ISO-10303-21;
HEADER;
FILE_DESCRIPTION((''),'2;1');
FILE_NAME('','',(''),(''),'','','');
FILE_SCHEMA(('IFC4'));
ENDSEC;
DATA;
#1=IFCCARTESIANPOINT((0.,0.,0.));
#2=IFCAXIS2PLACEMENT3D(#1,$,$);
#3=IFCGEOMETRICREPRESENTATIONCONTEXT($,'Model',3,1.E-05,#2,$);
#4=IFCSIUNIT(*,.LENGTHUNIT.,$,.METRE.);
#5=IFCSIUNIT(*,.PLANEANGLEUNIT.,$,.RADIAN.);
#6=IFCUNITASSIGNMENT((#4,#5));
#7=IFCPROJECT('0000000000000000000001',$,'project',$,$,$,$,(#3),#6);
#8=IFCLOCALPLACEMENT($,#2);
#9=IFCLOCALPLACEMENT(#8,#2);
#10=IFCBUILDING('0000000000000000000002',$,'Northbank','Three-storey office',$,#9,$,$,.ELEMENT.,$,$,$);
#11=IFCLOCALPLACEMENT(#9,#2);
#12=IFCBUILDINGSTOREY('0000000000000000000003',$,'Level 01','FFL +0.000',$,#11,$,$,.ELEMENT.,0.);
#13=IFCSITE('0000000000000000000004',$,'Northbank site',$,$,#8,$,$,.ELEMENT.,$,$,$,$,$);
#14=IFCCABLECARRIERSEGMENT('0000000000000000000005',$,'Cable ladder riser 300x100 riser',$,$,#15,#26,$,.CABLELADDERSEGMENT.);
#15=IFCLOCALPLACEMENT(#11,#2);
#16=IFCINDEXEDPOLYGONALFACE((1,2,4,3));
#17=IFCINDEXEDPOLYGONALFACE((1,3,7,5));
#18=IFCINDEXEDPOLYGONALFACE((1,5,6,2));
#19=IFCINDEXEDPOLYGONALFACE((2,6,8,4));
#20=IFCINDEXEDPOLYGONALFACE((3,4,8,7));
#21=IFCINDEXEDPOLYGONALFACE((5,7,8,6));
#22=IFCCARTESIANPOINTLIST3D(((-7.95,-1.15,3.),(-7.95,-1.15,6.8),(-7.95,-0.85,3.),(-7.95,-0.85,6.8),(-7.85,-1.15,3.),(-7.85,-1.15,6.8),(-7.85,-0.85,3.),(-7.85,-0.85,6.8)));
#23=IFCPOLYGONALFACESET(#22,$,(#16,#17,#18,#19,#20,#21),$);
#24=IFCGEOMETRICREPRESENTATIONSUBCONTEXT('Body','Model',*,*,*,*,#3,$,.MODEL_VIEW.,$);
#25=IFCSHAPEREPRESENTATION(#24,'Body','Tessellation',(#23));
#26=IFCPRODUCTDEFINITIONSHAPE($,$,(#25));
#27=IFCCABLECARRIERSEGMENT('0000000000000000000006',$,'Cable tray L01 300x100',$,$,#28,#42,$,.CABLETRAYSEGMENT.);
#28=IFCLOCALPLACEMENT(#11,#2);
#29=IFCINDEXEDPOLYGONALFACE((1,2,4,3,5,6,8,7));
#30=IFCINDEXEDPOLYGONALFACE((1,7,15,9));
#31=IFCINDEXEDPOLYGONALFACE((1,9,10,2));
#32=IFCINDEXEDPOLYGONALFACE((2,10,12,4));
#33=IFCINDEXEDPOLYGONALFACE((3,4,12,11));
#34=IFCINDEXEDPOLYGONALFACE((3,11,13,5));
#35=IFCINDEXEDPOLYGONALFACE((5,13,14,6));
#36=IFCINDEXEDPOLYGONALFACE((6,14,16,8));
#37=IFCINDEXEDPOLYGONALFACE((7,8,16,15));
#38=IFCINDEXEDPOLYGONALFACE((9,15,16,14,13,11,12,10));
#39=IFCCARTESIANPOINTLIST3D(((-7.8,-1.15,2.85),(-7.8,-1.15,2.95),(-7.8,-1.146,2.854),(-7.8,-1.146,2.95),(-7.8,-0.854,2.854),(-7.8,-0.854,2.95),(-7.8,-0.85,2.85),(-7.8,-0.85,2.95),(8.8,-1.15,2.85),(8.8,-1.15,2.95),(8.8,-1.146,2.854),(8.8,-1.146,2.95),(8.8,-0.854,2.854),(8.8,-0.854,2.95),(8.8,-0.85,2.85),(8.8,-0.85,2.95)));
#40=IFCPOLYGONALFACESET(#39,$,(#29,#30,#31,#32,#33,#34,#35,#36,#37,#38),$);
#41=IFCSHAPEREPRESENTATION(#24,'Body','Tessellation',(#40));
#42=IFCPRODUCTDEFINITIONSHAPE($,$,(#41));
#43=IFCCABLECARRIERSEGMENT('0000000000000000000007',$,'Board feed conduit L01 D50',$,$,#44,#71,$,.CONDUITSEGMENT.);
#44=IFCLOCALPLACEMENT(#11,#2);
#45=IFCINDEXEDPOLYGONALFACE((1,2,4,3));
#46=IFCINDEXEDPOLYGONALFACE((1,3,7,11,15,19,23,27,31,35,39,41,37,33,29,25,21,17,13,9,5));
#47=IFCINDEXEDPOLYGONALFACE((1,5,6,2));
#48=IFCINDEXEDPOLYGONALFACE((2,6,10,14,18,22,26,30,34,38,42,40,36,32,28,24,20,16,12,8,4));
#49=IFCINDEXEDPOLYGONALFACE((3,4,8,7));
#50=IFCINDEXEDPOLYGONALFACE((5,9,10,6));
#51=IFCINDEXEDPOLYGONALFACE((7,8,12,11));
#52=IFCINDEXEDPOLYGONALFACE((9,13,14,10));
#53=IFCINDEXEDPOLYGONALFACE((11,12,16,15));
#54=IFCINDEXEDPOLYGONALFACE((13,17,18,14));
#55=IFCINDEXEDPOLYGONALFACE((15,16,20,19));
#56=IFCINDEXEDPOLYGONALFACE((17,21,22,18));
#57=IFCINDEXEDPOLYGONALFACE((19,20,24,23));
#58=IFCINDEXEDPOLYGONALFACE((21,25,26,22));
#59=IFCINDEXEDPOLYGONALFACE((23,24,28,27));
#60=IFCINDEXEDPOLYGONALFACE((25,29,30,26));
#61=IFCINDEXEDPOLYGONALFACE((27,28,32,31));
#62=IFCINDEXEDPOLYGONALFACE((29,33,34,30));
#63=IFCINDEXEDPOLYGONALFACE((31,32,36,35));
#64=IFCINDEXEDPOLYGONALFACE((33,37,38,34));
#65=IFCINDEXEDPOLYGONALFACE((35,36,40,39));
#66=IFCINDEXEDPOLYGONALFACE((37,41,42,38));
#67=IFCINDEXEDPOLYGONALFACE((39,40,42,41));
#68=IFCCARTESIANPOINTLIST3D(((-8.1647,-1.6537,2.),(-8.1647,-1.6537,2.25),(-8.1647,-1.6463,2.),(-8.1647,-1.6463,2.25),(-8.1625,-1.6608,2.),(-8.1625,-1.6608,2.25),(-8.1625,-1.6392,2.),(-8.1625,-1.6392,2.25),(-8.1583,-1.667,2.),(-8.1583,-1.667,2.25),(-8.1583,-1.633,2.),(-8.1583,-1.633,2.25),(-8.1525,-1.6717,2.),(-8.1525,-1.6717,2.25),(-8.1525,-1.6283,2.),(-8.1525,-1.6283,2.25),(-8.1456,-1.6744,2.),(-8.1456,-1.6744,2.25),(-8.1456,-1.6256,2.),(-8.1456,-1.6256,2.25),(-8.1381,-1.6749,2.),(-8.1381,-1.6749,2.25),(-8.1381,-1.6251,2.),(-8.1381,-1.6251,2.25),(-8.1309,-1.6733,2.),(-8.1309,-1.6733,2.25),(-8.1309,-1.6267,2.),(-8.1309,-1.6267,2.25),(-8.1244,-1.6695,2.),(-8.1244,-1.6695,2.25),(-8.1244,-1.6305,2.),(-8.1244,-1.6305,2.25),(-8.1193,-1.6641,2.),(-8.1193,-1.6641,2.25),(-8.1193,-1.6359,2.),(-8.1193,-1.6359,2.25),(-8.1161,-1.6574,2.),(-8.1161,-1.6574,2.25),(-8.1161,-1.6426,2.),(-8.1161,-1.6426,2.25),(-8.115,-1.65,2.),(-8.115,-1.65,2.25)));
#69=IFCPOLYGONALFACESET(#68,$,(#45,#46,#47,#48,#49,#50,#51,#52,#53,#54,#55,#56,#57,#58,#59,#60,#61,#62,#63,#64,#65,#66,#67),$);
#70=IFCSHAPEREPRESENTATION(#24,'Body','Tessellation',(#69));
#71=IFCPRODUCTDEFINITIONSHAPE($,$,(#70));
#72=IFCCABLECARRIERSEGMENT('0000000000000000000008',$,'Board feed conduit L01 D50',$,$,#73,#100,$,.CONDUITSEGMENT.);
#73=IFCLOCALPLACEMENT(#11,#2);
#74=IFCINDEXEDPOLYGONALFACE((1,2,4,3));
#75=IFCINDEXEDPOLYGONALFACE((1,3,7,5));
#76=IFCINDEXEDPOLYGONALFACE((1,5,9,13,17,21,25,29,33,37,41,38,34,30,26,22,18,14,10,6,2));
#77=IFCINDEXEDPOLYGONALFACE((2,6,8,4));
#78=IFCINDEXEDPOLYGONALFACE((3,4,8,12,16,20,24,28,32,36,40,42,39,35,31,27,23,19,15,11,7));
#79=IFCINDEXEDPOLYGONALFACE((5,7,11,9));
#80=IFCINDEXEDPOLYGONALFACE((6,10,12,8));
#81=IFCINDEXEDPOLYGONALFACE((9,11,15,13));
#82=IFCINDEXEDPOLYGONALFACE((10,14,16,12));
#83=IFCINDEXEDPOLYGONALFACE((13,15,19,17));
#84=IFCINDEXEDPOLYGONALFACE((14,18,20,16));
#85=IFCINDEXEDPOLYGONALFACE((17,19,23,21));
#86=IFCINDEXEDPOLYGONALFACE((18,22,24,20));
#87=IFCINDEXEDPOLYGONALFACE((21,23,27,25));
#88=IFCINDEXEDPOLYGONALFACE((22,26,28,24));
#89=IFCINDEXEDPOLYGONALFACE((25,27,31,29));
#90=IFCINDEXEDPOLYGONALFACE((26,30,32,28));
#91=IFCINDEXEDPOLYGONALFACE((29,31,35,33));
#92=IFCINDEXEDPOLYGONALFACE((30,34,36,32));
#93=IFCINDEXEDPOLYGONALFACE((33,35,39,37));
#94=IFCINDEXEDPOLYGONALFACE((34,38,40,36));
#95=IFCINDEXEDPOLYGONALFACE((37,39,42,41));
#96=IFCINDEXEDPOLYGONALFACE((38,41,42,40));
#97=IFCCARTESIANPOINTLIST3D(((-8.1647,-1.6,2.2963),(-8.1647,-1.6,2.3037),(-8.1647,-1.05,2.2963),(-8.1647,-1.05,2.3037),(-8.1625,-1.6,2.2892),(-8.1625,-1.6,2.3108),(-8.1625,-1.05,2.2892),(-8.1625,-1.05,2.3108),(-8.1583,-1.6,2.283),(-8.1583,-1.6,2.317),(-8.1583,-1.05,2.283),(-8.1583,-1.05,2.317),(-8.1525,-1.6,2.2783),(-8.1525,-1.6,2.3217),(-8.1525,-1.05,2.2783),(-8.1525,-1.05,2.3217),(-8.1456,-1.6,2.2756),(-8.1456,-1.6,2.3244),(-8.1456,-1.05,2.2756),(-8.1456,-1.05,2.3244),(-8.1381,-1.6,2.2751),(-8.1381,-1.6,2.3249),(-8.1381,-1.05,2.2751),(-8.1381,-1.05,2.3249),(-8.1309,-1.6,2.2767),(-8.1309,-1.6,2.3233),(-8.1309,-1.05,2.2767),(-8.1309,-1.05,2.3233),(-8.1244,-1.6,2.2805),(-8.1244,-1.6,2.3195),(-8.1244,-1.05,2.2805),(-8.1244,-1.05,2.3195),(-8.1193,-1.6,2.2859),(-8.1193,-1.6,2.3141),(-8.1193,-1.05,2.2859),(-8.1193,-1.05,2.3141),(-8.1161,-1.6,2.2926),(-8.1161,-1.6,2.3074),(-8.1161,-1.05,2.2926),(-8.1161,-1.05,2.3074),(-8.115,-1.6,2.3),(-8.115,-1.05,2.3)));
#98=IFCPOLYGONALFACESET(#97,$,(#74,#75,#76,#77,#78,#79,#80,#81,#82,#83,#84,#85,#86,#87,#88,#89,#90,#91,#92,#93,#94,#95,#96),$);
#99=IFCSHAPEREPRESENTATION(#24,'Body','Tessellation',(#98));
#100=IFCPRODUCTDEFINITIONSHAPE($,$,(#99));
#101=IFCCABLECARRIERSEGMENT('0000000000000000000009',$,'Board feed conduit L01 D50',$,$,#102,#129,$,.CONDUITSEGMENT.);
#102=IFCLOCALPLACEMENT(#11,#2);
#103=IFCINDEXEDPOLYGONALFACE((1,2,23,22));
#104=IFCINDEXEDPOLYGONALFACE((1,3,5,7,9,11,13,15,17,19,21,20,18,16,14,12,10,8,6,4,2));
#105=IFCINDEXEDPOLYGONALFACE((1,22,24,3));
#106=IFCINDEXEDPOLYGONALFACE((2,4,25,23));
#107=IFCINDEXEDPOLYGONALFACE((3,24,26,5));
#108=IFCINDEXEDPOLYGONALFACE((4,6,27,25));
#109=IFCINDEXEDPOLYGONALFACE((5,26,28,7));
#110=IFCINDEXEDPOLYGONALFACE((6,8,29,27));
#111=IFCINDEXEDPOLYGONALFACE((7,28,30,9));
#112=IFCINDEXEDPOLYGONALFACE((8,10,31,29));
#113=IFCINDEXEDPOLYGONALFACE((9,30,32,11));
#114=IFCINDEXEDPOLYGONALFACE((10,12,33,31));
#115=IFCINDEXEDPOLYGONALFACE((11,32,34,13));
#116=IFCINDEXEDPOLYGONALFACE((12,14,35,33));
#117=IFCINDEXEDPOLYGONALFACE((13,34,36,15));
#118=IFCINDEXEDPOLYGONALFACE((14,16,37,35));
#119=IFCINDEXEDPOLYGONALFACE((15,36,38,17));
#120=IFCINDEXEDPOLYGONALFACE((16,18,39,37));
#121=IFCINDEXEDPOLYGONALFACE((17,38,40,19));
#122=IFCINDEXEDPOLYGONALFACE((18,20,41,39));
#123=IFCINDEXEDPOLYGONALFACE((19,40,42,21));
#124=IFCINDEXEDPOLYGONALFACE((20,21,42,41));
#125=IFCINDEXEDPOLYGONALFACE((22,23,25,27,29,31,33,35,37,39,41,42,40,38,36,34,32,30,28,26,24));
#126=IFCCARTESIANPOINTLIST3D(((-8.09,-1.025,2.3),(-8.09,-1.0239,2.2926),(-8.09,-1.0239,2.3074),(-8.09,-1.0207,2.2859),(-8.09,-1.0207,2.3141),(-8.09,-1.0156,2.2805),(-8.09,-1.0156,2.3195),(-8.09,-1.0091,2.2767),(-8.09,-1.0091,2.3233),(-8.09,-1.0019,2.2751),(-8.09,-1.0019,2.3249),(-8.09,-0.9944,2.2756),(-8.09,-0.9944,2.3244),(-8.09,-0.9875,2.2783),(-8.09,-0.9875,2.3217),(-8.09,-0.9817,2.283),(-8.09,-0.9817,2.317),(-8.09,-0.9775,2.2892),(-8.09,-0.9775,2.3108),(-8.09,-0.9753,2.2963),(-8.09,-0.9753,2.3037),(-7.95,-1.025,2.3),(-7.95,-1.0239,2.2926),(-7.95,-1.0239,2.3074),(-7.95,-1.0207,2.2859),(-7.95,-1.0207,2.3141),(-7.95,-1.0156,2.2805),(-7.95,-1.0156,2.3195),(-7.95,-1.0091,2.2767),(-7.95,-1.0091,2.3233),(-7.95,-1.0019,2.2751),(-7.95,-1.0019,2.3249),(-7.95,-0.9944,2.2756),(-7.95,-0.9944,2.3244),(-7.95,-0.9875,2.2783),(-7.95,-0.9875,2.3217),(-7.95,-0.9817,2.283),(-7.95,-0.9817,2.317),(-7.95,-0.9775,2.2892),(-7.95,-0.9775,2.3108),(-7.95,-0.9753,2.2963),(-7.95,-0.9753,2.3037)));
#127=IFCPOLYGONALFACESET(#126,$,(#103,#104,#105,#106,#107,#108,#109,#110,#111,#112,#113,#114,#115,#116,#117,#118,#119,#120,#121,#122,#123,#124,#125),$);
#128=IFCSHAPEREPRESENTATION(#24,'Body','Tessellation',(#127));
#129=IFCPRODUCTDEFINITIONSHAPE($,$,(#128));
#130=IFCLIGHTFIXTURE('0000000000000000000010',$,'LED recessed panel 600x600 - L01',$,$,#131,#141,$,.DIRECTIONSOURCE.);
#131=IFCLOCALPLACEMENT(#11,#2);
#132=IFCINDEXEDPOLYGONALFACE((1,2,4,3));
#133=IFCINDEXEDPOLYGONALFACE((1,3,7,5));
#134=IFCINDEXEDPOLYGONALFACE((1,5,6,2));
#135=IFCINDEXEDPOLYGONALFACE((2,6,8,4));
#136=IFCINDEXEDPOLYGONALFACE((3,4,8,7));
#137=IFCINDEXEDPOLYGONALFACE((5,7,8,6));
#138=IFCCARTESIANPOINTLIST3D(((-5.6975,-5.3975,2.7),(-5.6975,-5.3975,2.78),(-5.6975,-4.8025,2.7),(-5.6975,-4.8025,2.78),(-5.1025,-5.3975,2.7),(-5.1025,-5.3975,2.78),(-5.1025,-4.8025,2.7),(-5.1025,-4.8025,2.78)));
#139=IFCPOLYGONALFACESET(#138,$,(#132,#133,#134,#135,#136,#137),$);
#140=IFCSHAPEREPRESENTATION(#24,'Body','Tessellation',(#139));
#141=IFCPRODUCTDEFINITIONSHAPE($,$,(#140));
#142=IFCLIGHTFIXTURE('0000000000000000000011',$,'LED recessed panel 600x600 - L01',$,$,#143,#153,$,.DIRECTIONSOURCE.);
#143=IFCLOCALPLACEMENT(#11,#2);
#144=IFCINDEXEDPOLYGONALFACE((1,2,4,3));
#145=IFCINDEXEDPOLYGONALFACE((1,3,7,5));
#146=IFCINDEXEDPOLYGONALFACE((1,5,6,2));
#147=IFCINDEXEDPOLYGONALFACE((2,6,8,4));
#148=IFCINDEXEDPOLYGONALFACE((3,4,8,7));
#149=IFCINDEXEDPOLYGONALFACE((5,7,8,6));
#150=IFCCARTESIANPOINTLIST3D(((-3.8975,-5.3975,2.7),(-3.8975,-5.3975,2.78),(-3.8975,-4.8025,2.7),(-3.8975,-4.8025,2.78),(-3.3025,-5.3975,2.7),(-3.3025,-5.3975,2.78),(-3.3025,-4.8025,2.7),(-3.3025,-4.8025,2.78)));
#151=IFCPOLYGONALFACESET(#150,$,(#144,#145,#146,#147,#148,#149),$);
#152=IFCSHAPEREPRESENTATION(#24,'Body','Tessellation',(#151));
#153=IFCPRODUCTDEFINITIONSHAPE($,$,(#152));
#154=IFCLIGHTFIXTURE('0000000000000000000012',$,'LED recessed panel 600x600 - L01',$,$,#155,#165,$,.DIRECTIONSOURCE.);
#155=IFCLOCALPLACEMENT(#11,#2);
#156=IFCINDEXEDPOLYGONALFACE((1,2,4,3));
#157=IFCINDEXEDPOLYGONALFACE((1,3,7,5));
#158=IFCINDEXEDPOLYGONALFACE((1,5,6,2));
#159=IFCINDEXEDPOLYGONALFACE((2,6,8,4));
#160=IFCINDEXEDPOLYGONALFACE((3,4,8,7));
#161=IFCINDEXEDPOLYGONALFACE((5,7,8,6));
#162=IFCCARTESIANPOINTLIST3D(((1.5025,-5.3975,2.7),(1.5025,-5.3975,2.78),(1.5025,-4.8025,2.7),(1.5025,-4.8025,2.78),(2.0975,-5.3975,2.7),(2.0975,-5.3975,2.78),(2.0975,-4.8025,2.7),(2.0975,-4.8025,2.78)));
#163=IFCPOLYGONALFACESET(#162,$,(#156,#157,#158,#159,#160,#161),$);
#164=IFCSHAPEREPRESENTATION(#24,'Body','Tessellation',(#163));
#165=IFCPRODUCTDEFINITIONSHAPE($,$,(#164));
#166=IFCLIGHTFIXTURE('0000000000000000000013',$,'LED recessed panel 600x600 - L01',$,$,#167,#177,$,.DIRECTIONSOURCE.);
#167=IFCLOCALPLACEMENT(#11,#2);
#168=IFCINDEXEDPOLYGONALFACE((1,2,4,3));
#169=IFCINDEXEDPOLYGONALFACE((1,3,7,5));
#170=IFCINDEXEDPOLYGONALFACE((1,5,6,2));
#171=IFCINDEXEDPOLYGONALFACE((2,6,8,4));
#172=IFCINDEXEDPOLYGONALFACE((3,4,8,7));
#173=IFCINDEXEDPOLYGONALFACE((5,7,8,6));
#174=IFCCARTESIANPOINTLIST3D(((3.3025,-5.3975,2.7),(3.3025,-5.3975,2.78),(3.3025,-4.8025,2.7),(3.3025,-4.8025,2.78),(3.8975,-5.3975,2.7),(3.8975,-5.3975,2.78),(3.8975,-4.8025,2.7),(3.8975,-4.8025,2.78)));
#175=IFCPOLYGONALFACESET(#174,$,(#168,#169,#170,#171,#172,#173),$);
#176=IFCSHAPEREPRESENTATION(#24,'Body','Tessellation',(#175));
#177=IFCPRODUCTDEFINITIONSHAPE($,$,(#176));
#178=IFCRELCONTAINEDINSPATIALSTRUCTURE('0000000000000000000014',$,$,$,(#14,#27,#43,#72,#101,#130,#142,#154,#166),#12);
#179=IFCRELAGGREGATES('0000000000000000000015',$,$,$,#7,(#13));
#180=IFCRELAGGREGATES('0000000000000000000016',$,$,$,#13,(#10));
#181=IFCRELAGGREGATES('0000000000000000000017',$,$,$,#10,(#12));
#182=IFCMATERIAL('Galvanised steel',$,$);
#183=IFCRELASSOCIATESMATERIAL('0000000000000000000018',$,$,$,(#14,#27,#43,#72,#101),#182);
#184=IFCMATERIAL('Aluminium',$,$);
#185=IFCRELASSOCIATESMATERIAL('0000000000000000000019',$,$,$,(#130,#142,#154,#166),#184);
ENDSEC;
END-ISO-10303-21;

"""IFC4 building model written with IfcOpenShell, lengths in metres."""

from ifc_helpers import new_model, si_unit, frame, origin, place, context, subcontext, project, spatial, rectangle, circle, u_section, extrude, material, element, save


model = new_model("IFC4")

# Units and contexts
model_context = context("Model", 3, precision=1e-05, world=origin())
body_context = subcontext(model_context, "Body", "Model", "MODEL_VIEW")
ifc_project = project(units=[si_unit("LENGTHUNIT", "METRE"), si_unit("PLANEANGLEUNIT", "RADIAN")], contexts=[model_context])

# Site, building, storey
site_placement = place(None, origin())
site = spatial("IfcSite", under=ifc_project, at=site_placement, Name="Northbank site", CompositionType="ELEMENT")
building_placement = place(site_placement, origin())
building = spatial("IfcBuilding", under=site, at=building_placement, Name="Northbank", Description="Three-storey office", CompositionType="ELEMENT")
storey_placement = place(building_placement, origin())
storey = spatial("IfcBuildingStorey", under=building, at=storey_placement, Name="Level 01", Description="FFL +0.000", CompositionType="ELEMENT", Elevation=0.0)

# Shared definitions
ifc_material_1 = material(Name="Galvanised steel")

# Cable carrier segments
cable_carrier_segment_1_placement = place(storey_placement, origin())
element("IfcCableCarrierSegment", 1, at=cable_carrier_segment_1_placement, inside=storey, material=ifc_material_1, Name="Cable ladder riser 300x100 riser", PredefinedType="CABLELADDERSEGMENT", context=body_context, shape_type="SweptSolid", body=[
    extrude(rectangle(XDim=0.1, YDim=0.3), frame((-7.9, -1.0, 3.0), z_axis=(0.0, 0.0, 1.0), x_axis=(1.0, 0.0, 0.0)), (0.0, 0.0, 1.0), 3.8),
])
cable_carrier_segment_2_placement = place(storey_placement, origin())
element("IfcCableCarrierSegment", 2, at=cable_carrier_segment_2_placement, inside=storey, material=ifc_material_1, Name="Cable tray L01 300x100", PredefinedType="CABLETRAYSEGMENT", context=body_context, shape_type="SweptSolid", body=[
    extrude(u_section(Depth=0.3, FlangeWidth=0.1, WebThickness=0.004, FlangeThickness=0.004), frame((-7.8, -1.0, 2.9), z_axis=(1.0, 0.0, 0.0), x_axis=(0.0, 0.0, 1.0)), (0.0, 0.0, 1.0), 16.6),
])
cable_carrier_segment_3_placement = place(storey_placement, origin())
element("IfcCableCarrierSegment", 3, at=cable_carrier_segment_3_placement, inside=storey, material=ifc_material_1, Name="Board feed conduit L01 D50", PredefinedType="CONDUITSEGMENT", context=body_context, shape_type="SweptSolid", body=[
    extrude(circle(Radius=0.025), frame((-8.14, -1.65, 2.0), z_axis=(0.0, 0.0, 1.0), x_axis=(1.0, 0.0, 0.0)), (0.0, 0.0, 1.0), 0.25),
])
cable_carrier_segment_4_placement = place(storey_placement, origin())
element("IfcCableCarrierSegment", 4, at=cable_carrier_segment_4_placement, inside=storey, material=ifc_material_1, Name="Board feed conduit L01 D50", PredefinedType="CONDUITSEGMENT", context=body_context, shape_type="SweptSolid", body=[
    extrude(circle(Radius=0.025), frame((-8.14, -1.6, 2.3), z_axis=(0.0, 1.0, 0.0), x_axis=(1.0, 0.0, 0.0)), (0.0, 0.0, 1.0), 0.55),
])
cable_carrier_segment_5_placement = place(storey_placement, origin())
element("IfcCableCarrierSegment", 5, at=cable_carrier_segment_5_placement, inside=storey, material=ifc_material_1, Name="Board feed conduit L01 D50", PredefinedType="CONDUITSEGMENT", context=body_context, shape_type="SweptSolid", body=[
    extrude(circle(Radius=0.025), frame((-8.09, -1.0, 2.3), z_axis=(1.0, 0.0, 0.0), x_axis=(0.0, -1.0, 0.0)), (0.0, 0.0, 1.0), 0.14),
])

# Light fixtures
ifc_material_2 = material(Name="Aluminium")
light_fixture_1_placement = place(storey_placement, origin())
element("IfcLightFixture", 6, at=light_fixture_1_placement, inside=storey, material=ifc_material_2, Name="LED recessed panel 600x600 - L01", PredefinedType="DIRECTIONSOURCE", context=body_context, shape_type="SweptSolid", body=[
    extrude(rectangle(XDim=0.595, YDim=0.595), frame((-5.4, -5.1, 2.7)), (0.0, 0.0, 1.0), 0.08),
])
light_fixture_2_placement = place(storey_placement, origin())
element("IfcLightFixture", 7, at=light_fixture_2_placement, inside=storey, material=ifc_material_2, Name="LED recessed panel 600x600 - L01", PredefinedType="DIRECTIONSOURCE", context=body_context, shape_type="SweptSolid", body=[
    extrude(rectangle(XDim=0.595, YDim=0.595), frame((-3.6, -5.1, 2.7)), (0.0, 0.0, 1.0), 0.08),
])
light_fixture_3_placement = place(storey_placement, origin())
element("IfcLightFixture", 8, at=light_fixture_3_placement, inside=storey, material=ifc_material_2, Name="LED recessed panel 600x600 - L01", PredefinedType="DIRECTIONSOURCE", context=body_context, shape_type="SweptSolid", body=[
    extrude(rectangle(XDim=0.595, YDim=0.595), frame((1.8, -5.1, 2.7)), (0.0, 0.0, 1.0), 0.08),
])
light_fixture_4_placement = place(storey_placement, origin())
element("IfcLightFixture", 9, at=light_fixture_4_placement, inside=storey, material=ifc_material_2, Name="LED recessed panel 600x600 - L01", PredefinedType="DIRECTIONSOURCE", context=body_context, shape_type="SweptSolid", body=[
    extrude(rectangle(XDim=0.595, YDim=0.595), frame((3.6, -5.1, 2.7)), (0.0, 0.0, 1.0), 0.08),
])

save(model, "model.ifc")
